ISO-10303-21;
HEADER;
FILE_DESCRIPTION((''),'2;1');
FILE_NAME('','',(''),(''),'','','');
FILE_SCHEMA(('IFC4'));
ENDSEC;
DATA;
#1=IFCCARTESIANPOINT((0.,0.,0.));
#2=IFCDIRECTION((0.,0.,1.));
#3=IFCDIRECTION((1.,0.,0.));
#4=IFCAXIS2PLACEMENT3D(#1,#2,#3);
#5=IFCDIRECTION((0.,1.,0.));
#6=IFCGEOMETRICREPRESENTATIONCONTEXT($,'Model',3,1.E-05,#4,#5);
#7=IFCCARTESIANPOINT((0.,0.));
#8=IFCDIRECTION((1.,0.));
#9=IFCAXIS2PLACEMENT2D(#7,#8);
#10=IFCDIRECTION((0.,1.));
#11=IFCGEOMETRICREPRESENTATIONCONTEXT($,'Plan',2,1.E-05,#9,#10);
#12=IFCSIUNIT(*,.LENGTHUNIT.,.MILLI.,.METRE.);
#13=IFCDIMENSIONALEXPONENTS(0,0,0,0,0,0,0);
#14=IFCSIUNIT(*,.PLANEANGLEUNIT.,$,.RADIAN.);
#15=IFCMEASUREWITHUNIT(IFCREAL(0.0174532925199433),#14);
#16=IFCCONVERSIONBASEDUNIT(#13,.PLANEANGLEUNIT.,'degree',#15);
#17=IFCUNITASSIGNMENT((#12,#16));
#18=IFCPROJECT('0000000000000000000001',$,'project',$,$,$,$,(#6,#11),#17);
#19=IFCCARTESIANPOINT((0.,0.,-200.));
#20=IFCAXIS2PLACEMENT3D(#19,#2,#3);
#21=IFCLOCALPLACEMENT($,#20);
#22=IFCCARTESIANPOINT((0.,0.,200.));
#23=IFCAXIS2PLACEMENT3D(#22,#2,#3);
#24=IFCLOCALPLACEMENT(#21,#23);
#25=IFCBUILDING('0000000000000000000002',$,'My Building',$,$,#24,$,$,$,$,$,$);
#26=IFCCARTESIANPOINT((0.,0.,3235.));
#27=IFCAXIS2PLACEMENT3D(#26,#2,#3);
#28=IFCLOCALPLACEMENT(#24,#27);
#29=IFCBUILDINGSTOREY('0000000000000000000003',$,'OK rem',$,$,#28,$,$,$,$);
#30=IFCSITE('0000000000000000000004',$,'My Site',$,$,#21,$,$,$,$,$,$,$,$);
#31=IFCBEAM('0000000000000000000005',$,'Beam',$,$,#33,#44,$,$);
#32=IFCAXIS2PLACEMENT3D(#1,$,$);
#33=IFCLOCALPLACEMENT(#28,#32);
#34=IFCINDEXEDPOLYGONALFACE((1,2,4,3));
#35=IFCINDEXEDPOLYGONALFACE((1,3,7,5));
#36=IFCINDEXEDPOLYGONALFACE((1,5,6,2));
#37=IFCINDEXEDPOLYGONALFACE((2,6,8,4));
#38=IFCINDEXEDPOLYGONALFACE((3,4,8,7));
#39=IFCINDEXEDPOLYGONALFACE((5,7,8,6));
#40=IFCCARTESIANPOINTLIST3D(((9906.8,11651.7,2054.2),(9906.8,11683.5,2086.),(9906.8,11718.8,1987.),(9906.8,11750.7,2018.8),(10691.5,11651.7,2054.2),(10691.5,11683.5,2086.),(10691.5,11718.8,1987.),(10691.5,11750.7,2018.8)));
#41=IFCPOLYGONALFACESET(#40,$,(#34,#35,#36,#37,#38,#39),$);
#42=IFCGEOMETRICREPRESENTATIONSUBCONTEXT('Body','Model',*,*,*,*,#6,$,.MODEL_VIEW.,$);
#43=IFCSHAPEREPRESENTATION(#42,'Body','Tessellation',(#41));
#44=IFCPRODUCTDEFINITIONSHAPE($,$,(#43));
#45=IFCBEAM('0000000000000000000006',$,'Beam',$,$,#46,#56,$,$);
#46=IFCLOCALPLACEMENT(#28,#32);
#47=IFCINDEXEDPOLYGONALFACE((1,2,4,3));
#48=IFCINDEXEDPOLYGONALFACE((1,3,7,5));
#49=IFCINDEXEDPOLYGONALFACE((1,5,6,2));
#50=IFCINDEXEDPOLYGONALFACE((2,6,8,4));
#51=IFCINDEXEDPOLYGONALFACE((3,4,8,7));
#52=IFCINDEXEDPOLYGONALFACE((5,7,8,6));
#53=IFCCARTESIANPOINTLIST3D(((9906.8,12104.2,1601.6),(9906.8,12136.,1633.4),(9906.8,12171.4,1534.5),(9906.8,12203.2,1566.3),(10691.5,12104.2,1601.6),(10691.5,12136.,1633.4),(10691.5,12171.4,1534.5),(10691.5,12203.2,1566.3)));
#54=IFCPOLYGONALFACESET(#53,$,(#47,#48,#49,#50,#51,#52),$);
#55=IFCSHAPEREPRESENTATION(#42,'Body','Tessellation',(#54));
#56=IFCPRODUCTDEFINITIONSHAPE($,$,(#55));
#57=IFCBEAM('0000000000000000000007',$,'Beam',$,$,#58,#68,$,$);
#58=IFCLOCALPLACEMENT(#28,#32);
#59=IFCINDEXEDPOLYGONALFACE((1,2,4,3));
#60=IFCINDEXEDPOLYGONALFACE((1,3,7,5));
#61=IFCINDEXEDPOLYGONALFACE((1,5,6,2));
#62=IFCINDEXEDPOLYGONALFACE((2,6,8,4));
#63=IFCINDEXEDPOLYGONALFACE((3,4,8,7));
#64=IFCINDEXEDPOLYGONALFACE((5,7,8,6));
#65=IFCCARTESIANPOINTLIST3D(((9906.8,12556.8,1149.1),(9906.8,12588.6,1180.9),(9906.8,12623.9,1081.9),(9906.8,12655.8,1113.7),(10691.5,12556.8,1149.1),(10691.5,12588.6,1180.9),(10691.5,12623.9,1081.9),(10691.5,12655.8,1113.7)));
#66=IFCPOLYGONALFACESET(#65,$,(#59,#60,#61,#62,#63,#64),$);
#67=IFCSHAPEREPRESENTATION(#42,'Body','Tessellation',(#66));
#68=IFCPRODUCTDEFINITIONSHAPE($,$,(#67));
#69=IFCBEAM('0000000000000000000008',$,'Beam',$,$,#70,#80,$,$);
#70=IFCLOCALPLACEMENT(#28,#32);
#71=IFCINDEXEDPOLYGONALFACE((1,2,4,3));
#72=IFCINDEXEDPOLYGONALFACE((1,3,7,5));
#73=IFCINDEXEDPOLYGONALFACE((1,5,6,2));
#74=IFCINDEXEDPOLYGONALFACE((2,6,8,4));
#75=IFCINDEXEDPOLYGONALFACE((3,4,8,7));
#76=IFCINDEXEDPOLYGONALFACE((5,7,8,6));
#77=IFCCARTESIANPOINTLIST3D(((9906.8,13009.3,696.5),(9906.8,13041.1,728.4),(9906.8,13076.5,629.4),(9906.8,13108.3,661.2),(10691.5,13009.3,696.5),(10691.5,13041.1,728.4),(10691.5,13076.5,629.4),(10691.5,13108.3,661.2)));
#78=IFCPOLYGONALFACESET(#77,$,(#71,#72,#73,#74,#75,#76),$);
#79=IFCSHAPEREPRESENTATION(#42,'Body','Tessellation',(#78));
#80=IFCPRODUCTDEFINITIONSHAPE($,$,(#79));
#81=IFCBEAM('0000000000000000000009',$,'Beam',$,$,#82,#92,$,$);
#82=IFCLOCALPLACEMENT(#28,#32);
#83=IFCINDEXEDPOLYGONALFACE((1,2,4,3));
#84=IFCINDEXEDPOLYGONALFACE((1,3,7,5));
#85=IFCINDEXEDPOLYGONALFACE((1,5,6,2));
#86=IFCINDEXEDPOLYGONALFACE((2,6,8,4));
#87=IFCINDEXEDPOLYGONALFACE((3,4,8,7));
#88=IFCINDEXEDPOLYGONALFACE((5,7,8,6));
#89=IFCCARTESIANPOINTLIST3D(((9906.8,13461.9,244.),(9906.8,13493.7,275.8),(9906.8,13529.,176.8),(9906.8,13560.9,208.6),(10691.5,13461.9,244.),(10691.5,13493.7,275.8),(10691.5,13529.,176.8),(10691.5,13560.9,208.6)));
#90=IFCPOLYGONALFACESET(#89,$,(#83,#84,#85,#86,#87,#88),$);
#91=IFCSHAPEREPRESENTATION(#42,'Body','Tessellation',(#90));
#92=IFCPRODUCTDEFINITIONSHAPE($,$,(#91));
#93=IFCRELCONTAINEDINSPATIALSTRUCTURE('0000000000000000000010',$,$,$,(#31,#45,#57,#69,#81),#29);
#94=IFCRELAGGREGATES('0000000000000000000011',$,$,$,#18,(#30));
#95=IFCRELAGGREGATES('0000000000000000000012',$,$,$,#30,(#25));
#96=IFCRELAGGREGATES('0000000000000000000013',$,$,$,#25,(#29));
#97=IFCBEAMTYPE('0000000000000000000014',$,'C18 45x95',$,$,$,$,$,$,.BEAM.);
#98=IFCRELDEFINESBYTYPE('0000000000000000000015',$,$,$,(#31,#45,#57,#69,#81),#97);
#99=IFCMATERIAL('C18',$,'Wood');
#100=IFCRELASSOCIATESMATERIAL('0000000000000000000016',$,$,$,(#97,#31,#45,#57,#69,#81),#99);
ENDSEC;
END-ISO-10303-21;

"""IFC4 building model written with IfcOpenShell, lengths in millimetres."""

from ifc_helpers import new_model, entity, si_unit, converted_unit, direction, frame, origin_with_axes, origin_2d_with_axis, place, context, subcontext, project, spatial, rectangle, extrude, material, material_profile, profile_set, profile_usage, type_object, element, save


model = new_model("IFC4")

# Units and contexts
model_context = context("Model", 3, precision=1e-05, world=origin_with_axes(), true_north=direction((0.0, 1.0, 0.0)))
plan_context = context("Plan", 2, precision=1e-05, world=origin_2d_with_axis(), true_north=direction((0.0, 1.0)))
body_context = subcontext(model_context, "Body", "Model", "MODEL_VIEW")
ifc_project = project(units=[si_unit("LENGTHUNIT", "METRE", prefix="MILLI"), converted_unit("PLANEANGLEUNIT", "degree", entity("IfcReal", 0.0174532925199433), si_unit("PLANEANGLEUNIT", "RADIAN"), dimensions=[0, 0, 0, 0, 0, 0, 0])], contexts=[model_context, plan_context])

# Site, building, storey
site_placement = place(None, frame((0.0, 0.0, -200.0), z_axis=(0.0, 0.0, 1.0), x_axis=(1.0, 0.0, 0.0)))
site = spatial("IfcSite", under=ifc_project, at=site_placement, Name="My Site")
building_placement = place(site_placement, frame((0.0, 0.0, 200.0), z_axis=(0.0, 0.0, 1.0), x_axis=(1.0, 0.0, 0.0)))
building = spatial("IfcBuilding", under=site, at=building_placement, Name="My Building")
storey_placement = place(building_placement, frame((0.0, 0.0, 3235.0), z_axis=(0.0, 0.0, 1.0), x_axis=(1.0, 0.0, 0.0)))
storey = spatial("IfcBuildingStorey", under=building, at=storey_placement, Name="OK rem")

# Beams
ifc_material = material(Name="C18", Category="Wood")
ifc_material_profile_1 = material_profile(ifc_material, rectangle(XDim=45.0, YDim=95.0))
ifc_profile_set_1 = profile_set([ifc_material_profile_1], Name="woodStructural")
beam_type_1 = type_object("IfcBeamType", Name="C18 45x95", PredefinedType="BEAM", material=ifc_profile_set_1)
ifc_profile_usage_1 = profile_usage(ifc_profile_set_1, cardinal=5)
beam_1_placement = place(storey_placement, frame((9906.8, 11701.2, 2036.5), z_axis=(1.0, 0.0, 0.0), x_axis=(0.0, 0.707107, 0.707107)))
element("IfcBeam", 1, at=beam_1_placement, inside=storey, type_object=beam_type_1, material=ifc_profile_usage_1, Name="Beam", context=body_context, shape_type="SweptSolid", body=[
    extrude(rectangle(XDim=45.0, YDim=95.0), origin_with_axes(), (0.0, 0.0, 1.0), 784.6),
])
ifc_profile_usage_2 = profile_usage(ifc_profile_set_1, cardinal=5)
beam_2_placement = place(storey_placement, frame((9906.8, 12153.7, 1584.0), z_axis=(1.0, 0.0, 0.0), x_axis=(0.0, 0.707107, 0.707107)))
element("IfcBeam", 2, at=beam_2_placement, inside=storey, type_object=beam_type_1, material=ifc_profile_usage_2, Name="Beam", context=body_context, shape_type="SweptSolid", body=[
    extrude(rectangle(XDim=45.0, YDim=95.0), origin_with_axes(), (0.0, 0.0, 1.0), 784.6),
])
ifc_profile_usage_3 = profile_usage(ifc_profile_set_1, cardinal=5)
beam_3_placement = place(storey_placement, frame((9906.8, 12606.3, 1131.4), z_axis=(1.0, 0.0, 0.0), x_axis=(0.0, 0.707107, 0.707107)))
element("IfcBeam", 3, at=beam_3_placement, inside=storey, type_object=beam_type_1, material=ifc_profile_usage_3, Name="Beam", context=body_context, shape_type="SweptSolid", body=[
    extrude(rectangle(XDim=45.0, YDim=95.0), origin_with_axes(), (0.0, 0.0, 1.0), 784.6),
])
ifc_profile_usage_4 = profile_usage(ifc_profile_set_1, cardinal=5)
beam_4_placement = place(storey_placement, frame((9906.8, 13058.8, 678.9), z_axis=(1.0, 0.0, 0.0), x_axis=(0.0, 0.707107, 0.707107)))
element("IfcBeam", 4, at=beam_4_placement, inside=storey, type_object=beam_type_1, material=ifc_profile_usage_4, Name="Beam", context=body_context, shape_type="SweptSolid", body=[
    extrude(rectangle(XDim=45.0, YDim=95.0), origin_with_axes(), (0.0, 0.0, 1.0), 784.6),
])
ifc_profile_usage_5 = profile_usage(ifc_profile_set_1, cardinal=5)
beam_5_placement = place(storey_placement, frame((9906.8, 13511.4, 226.3), z_axis=(1.0, 0.0, 0.0), x_axis=(0.0, 0.707107, 0.707107)))
element("IfcBeam", 5, at=beam_5_placement, inside=storey, type_object=beam_type_1, material=ifc_profile_usage_5, Name="Beam", context=body_context, shape_type="SweptSolid", body=[
    extrude(rectangle(XDim=45.0, YDim=95.0), origin_with_axes(), (0.0, 0.0, 1.0), 784.6),
])

save(model, "model.ifc")
